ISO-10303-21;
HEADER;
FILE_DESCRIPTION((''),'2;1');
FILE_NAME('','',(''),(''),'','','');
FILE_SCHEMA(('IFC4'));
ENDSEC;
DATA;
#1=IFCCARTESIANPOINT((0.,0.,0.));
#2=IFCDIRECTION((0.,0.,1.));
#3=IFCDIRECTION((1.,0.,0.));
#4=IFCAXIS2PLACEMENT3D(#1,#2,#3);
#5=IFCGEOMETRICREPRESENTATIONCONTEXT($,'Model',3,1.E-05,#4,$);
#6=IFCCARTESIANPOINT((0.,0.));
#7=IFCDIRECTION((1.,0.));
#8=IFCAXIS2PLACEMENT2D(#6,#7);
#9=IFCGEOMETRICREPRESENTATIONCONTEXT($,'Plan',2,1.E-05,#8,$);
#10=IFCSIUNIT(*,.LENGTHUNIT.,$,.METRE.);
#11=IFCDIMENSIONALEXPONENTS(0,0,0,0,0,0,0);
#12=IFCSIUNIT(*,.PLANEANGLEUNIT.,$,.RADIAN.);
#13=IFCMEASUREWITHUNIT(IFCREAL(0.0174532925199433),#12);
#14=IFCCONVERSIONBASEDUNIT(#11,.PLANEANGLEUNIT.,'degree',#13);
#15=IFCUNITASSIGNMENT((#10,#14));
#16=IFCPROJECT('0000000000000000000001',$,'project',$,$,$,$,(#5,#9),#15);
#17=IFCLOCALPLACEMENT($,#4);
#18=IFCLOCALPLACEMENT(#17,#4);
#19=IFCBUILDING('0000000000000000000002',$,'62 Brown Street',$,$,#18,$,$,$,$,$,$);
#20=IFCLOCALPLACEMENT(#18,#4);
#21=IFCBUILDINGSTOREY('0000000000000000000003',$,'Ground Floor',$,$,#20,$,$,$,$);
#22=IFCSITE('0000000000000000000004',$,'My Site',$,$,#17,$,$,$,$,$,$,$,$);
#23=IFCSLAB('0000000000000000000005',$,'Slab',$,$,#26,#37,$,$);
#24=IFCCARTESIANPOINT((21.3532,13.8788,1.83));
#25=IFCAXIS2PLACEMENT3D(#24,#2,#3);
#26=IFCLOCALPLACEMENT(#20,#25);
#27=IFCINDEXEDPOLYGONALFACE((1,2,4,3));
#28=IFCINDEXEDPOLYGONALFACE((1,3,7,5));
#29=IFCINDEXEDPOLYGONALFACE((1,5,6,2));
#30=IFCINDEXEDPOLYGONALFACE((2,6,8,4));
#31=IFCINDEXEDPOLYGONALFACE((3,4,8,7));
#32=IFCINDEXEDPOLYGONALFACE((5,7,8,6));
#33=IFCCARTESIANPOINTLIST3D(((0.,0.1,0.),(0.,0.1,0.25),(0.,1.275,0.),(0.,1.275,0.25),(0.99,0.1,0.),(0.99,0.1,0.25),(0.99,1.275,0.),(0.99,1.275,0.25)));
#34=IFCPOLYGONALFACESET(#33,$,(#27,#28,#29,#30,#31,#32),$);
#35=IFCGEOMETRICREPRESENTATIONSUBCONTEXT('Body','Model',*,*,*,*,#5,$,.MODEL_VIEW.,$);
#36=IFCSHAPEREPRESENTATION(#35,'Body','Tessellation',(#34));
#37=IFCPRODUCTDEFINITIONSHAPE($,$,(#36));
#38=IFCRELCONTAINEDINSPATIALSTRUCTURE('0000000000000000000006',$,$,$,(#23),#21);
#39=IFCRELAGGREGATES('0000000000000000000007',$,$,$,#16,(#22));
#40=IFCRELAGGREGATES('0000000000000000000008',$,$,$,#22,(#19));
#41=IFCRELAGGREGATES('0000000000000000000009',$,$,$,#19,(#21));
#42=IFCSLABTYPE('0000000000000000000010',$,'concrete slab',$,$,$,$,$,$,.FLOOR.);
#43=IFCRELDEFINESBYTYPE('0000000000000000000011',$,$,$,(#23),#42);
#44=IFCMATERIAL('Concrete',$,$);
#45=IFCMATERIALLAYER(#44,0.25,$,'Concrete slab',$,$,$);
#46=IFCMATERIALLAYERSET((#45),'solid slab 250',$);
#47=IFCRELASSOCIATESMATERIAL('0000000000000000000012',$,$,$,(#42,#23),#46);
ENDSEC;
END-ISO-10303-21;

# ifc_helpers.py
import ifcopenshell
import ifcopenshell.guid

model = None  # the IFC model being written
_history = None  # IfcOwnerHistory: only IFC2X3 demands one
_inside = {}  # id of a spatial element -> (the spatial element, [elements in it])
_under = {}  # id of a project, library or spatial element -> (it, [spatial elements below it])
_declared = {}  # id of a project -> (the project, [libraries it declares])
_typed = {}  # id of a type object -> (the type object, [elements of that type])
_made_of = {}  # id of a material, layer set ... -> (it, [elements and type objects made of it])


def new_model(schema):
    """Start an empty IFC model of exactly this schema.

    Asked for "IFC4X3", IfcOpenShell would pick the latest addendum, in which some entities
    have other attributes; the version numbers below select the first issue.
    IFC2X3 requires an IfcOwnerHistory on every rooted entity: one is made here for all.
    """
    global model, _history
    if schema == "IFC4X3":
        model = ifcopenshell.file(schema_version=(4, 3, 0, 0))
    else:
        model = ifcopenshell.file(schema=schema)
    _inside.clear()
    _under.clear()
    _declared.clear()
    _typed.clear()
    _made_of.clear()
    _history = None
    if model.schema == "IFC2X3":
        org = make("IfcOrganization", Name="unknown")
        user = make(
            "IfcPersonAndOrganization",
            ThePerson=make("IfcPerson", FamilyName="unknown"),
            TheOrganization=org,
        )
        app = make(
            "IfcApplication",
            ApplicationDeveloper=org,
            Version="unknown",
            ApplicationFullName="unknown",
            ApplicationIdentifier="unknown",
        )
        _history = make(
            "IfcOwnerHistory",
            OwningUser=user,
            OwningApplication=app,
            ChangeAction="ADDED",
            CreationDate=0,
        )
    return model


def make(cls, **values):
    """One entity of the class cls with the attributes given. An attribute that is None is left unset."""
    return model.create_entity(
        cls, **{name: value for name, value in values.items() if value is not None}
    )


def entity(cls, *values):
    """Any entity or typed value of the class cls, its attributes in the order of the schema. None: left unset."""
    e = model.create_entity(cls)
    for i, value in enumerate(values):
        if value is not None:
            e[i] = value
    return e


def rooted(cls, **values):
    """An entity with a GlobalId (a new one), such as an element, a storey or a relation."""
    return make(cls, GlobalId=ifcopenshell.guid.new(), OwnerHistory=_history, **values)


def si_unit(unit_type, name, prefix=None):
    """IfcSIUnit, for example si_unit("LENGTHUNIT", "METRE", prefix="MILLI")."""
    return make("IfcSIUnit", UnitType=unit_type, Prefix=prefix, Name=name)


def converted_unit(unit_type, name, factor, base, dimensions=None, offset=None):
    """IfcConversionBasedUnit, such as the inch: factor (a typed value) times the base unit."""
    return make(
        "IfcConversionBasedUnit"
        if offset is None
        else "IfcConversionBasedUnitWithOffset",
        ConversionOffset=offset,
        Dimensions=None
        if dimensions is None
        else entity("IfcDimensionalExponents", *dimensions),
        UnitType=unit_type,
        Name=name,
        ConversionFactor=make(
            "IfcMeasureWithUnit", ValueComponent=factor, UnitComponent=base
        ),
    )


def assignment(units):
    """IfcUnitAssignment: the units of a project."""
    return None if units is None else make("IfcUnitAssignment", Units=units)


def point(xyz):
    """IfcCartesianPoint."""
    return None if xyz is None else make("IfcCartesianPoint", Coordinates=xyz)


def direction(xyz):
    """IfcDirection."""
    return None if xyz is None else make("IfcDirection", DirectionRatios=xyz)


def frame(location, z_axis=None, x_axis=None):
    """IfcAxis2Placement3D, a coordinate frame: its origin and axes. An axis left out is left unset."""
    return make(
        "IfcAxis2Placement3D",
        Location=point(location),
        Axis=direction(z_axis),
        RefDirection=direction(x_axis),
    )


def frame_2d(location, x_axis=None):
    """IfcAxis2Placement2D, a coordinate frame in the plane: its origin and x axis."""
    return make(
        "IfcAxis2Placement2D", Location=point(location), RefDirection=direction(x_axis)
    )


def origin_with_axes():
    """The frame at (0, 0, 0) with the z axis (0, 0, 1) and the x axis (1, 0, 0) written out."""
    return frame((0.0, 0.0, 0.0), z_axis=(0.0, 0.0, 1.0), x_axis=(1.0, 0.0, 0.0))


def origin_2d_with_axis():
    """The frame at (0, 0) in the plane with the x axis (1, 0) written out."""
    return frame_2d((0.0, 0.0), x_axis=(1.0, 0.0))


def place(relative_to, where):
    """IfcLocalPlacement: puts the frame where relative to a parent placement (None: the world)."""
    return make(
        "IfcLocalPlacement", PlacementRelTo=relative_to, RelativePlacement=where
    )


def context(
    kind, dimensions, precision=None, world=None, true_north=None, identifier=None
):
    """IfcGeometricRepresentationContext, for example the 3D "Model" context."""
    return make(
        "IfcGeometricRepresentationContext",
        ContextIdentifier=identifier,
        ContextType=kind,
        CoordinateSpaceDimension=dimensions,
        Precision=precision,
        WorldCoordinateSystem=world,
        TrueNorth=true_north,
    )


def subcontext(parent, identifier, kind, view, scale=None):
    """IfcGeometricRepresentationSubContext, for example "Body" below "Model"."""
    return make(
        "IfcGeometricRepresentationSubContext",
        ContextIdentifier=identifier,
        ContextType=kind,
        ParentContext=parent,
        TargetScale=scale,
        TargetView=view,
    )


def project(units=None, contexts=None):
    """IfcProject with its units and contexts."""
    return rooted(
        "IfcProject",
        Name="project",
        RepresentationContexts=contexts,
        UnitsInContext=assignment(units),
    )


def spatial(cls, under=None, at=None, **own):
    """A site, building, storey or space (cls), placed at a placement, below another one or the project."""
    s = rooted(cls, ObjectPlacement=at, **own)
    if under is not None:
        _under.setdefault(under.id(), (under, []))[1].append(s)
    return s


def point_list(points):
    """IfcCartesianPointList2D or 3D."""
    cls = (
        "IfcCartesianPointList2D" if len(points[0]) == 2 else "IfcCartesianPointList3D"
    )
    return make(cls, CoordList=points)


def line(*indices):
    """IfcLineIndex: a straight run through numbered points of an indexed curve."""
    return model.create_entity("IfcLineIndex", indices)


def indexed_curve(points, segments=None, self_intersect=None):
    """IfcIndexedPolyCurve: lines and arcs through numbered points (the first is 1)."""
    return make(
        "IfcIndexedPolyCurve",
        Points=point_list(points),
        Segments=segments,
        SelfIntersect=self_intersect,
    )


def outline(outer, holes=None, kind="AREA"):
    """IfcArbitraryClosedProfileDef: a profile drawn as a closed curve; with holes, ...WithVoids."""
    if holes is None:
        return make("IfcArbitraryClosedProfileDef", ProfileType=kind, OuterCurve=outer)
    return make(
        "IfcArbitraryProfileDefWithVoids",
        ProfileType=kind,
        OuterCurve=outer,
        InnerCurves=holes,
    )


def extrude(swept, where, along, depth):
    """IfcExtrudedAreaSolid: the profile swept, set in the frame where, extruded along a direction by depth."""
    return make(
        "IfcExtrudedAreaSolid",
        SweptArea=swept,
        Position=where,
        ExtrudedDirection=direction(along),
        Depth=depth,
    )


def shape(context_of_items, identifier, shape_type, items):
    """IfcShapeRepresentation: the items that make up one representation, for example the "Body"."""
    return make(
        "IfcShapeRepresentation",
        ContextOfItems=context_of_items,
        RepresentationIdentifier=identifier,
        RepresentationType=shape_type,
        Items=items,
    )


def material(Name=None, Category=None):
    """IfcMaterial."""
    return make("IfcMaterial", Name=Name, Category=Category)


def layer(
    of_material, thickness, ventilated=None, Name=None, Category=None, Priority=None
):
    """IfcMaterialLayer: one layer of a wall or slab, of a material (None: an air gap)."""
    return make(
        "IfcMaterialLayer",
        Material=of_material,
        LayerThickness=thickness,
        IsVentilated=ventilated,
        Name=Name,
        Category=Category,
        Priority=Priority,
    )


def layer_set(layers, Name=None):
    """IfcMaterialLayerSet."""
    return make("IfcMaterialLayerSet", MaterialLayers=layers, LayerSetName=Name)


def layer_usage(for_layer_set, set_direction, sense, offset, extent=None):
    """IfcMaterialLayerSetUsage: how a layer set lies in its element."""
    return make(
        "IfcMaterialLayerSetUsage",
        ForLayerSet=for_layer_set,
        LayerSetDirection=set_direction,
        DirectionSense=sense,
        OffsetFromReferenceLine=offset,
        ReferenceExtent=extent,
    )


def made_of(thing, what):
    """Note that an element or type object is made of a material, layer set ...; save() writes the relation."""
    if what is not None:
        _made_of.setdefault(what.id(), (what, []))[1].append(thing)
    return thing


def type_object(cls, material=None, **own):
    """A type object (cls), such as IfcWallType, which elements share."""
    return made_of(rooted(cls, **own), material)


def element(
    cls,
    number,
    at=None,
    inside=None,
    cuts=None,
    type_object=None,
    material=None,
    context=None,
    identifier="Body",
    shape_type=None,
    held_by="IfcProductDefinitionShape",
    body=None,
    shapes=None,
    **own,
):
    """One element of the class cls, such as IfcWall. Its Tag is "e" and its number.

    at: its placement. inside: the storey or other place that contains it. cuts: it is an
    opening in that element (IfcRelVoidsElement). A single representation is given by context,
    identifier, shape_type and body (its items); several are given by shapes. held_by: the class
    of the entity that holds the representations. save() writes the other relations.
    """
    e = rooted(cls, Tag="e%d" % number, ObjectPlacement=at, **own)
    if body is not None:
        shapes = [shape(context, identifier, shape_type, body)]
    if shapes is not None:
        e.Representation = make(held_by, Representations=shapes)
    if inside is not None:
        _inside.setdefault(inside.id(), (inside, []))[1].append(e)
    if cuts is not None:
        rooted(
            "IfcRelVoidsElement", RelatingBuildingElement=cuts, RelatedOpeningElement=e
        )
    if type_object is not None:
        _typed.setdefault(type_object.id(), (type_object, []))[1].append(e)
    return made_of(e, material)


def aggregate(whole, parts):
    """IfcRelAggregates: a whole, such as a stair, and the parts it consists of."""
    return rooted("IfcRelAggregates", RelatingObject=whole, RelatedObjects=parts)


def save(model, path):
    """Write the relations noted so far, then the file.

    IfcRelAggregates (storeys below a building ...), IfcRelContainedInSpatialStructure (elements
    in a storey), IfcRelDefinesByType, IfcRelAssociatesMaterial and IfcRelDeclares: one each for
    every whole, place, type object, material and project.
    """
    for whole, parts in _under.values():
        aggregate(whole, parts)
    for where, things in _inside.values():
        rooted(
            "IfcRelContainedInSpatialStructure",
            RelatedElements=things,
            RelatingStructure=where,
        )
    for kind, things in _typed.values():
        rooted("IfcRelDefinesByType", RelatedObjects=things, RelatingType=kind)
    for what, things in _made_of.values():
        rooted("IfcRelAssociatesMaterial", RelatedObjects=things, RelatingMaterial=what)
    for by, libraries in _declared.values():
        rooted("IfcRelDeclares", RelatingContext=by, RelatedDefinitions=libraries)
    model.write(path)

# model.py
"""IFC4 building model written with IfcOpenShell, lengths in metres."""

from ifc_helpers import new_model, entity, si_unit, converted_unit, frame, origin_with_axes, origin_2d_with_axis, place, context, subcontext, project, spatial, line, indexed_curve, outline, extrude, material, layer, layer_set, layer_usage, type_object, element, save


model = new_model("IFC4")

# Units and contexts
model_context = context("Model", 3, precision=1e-05, world=origin_with_axes())
plan_context = context("Plan", 2, precision=1e-05, world=origin_2d_with_axis())
body_context_1 = subcontext(model_context, "Body", "Model", "MODEL_VIEW")
ifc_project = project(units=[si_unit("LENGTHUNIT", "METRE"), converted_unit("PLANEANGLEUNIT", "degree", entity("IfcReal", 0.0174532925199433), si_unit("PLANEANGLEUNIT", "RADIAN"), dimensions=[0, 0, 0, 0, 0, 0, 0])], contexts=[model_context, plan_context])

# Site, building, storey
site_placement = place(None, origin_with_axes())
site = spatial("IfcSite", under=ifc_project, at=site_placement, Name="My Site")
building_placement = place(site_placement, origin_with_axes())
building = spatial("IfcBuilding", under=site, at=building_placement, Name="62 Brown Street")
storey_placement = place(building_placement, origin_with_axes())
storey = spatial("IfcBuildingStorey", under=building, at=storey_placement, Name="Ground Floor")

# Shared definitions
ifc_material_1 = material(Name="Concrete")

# Slab
ifc_layer_1 = layer(ifc_material_1, 0.25, Name="Concrete slab")
ifc_layer_set_1 = layer_set([ifc_layer_1], Name="solid slab 250")
ifc_layer_usage_1 = layer_usage(ifc_layer_set_1, "AXIS3", "POSITIVE", 0.0)
slab_type = type_object("IfcSlabType", Name="concrete slab", PredefinedType="FLOOR", material=ifc_layer_set_1)
slab_1_placement = place(storey_placement, frame((21.3532, 13.8788, 1.83), z_axis=(0.0, 0.0, 1.0), x_axis=(1.0, 0.0, 0.0)))
element("IfcSlab", 1, at=slab_1_placement, inside=storey, type_object=slab_type, material=ifc_layer_usage_1, Name="Slab", context=body_context_1, shape_type="SweptSolid", body=[
    extrude(outline(indexed_curve([(0.99, 1.275), (0.99, 0.1), (0.0, 0.1), (0.0, 1.275)], segments=[line(3, 2), line(2, 1), line(1, 4), line(4, 3)], self_intersect=False)), None, (0.0, 0.0, 1.0), 0.25),
])

save(model, "model.ifc")
